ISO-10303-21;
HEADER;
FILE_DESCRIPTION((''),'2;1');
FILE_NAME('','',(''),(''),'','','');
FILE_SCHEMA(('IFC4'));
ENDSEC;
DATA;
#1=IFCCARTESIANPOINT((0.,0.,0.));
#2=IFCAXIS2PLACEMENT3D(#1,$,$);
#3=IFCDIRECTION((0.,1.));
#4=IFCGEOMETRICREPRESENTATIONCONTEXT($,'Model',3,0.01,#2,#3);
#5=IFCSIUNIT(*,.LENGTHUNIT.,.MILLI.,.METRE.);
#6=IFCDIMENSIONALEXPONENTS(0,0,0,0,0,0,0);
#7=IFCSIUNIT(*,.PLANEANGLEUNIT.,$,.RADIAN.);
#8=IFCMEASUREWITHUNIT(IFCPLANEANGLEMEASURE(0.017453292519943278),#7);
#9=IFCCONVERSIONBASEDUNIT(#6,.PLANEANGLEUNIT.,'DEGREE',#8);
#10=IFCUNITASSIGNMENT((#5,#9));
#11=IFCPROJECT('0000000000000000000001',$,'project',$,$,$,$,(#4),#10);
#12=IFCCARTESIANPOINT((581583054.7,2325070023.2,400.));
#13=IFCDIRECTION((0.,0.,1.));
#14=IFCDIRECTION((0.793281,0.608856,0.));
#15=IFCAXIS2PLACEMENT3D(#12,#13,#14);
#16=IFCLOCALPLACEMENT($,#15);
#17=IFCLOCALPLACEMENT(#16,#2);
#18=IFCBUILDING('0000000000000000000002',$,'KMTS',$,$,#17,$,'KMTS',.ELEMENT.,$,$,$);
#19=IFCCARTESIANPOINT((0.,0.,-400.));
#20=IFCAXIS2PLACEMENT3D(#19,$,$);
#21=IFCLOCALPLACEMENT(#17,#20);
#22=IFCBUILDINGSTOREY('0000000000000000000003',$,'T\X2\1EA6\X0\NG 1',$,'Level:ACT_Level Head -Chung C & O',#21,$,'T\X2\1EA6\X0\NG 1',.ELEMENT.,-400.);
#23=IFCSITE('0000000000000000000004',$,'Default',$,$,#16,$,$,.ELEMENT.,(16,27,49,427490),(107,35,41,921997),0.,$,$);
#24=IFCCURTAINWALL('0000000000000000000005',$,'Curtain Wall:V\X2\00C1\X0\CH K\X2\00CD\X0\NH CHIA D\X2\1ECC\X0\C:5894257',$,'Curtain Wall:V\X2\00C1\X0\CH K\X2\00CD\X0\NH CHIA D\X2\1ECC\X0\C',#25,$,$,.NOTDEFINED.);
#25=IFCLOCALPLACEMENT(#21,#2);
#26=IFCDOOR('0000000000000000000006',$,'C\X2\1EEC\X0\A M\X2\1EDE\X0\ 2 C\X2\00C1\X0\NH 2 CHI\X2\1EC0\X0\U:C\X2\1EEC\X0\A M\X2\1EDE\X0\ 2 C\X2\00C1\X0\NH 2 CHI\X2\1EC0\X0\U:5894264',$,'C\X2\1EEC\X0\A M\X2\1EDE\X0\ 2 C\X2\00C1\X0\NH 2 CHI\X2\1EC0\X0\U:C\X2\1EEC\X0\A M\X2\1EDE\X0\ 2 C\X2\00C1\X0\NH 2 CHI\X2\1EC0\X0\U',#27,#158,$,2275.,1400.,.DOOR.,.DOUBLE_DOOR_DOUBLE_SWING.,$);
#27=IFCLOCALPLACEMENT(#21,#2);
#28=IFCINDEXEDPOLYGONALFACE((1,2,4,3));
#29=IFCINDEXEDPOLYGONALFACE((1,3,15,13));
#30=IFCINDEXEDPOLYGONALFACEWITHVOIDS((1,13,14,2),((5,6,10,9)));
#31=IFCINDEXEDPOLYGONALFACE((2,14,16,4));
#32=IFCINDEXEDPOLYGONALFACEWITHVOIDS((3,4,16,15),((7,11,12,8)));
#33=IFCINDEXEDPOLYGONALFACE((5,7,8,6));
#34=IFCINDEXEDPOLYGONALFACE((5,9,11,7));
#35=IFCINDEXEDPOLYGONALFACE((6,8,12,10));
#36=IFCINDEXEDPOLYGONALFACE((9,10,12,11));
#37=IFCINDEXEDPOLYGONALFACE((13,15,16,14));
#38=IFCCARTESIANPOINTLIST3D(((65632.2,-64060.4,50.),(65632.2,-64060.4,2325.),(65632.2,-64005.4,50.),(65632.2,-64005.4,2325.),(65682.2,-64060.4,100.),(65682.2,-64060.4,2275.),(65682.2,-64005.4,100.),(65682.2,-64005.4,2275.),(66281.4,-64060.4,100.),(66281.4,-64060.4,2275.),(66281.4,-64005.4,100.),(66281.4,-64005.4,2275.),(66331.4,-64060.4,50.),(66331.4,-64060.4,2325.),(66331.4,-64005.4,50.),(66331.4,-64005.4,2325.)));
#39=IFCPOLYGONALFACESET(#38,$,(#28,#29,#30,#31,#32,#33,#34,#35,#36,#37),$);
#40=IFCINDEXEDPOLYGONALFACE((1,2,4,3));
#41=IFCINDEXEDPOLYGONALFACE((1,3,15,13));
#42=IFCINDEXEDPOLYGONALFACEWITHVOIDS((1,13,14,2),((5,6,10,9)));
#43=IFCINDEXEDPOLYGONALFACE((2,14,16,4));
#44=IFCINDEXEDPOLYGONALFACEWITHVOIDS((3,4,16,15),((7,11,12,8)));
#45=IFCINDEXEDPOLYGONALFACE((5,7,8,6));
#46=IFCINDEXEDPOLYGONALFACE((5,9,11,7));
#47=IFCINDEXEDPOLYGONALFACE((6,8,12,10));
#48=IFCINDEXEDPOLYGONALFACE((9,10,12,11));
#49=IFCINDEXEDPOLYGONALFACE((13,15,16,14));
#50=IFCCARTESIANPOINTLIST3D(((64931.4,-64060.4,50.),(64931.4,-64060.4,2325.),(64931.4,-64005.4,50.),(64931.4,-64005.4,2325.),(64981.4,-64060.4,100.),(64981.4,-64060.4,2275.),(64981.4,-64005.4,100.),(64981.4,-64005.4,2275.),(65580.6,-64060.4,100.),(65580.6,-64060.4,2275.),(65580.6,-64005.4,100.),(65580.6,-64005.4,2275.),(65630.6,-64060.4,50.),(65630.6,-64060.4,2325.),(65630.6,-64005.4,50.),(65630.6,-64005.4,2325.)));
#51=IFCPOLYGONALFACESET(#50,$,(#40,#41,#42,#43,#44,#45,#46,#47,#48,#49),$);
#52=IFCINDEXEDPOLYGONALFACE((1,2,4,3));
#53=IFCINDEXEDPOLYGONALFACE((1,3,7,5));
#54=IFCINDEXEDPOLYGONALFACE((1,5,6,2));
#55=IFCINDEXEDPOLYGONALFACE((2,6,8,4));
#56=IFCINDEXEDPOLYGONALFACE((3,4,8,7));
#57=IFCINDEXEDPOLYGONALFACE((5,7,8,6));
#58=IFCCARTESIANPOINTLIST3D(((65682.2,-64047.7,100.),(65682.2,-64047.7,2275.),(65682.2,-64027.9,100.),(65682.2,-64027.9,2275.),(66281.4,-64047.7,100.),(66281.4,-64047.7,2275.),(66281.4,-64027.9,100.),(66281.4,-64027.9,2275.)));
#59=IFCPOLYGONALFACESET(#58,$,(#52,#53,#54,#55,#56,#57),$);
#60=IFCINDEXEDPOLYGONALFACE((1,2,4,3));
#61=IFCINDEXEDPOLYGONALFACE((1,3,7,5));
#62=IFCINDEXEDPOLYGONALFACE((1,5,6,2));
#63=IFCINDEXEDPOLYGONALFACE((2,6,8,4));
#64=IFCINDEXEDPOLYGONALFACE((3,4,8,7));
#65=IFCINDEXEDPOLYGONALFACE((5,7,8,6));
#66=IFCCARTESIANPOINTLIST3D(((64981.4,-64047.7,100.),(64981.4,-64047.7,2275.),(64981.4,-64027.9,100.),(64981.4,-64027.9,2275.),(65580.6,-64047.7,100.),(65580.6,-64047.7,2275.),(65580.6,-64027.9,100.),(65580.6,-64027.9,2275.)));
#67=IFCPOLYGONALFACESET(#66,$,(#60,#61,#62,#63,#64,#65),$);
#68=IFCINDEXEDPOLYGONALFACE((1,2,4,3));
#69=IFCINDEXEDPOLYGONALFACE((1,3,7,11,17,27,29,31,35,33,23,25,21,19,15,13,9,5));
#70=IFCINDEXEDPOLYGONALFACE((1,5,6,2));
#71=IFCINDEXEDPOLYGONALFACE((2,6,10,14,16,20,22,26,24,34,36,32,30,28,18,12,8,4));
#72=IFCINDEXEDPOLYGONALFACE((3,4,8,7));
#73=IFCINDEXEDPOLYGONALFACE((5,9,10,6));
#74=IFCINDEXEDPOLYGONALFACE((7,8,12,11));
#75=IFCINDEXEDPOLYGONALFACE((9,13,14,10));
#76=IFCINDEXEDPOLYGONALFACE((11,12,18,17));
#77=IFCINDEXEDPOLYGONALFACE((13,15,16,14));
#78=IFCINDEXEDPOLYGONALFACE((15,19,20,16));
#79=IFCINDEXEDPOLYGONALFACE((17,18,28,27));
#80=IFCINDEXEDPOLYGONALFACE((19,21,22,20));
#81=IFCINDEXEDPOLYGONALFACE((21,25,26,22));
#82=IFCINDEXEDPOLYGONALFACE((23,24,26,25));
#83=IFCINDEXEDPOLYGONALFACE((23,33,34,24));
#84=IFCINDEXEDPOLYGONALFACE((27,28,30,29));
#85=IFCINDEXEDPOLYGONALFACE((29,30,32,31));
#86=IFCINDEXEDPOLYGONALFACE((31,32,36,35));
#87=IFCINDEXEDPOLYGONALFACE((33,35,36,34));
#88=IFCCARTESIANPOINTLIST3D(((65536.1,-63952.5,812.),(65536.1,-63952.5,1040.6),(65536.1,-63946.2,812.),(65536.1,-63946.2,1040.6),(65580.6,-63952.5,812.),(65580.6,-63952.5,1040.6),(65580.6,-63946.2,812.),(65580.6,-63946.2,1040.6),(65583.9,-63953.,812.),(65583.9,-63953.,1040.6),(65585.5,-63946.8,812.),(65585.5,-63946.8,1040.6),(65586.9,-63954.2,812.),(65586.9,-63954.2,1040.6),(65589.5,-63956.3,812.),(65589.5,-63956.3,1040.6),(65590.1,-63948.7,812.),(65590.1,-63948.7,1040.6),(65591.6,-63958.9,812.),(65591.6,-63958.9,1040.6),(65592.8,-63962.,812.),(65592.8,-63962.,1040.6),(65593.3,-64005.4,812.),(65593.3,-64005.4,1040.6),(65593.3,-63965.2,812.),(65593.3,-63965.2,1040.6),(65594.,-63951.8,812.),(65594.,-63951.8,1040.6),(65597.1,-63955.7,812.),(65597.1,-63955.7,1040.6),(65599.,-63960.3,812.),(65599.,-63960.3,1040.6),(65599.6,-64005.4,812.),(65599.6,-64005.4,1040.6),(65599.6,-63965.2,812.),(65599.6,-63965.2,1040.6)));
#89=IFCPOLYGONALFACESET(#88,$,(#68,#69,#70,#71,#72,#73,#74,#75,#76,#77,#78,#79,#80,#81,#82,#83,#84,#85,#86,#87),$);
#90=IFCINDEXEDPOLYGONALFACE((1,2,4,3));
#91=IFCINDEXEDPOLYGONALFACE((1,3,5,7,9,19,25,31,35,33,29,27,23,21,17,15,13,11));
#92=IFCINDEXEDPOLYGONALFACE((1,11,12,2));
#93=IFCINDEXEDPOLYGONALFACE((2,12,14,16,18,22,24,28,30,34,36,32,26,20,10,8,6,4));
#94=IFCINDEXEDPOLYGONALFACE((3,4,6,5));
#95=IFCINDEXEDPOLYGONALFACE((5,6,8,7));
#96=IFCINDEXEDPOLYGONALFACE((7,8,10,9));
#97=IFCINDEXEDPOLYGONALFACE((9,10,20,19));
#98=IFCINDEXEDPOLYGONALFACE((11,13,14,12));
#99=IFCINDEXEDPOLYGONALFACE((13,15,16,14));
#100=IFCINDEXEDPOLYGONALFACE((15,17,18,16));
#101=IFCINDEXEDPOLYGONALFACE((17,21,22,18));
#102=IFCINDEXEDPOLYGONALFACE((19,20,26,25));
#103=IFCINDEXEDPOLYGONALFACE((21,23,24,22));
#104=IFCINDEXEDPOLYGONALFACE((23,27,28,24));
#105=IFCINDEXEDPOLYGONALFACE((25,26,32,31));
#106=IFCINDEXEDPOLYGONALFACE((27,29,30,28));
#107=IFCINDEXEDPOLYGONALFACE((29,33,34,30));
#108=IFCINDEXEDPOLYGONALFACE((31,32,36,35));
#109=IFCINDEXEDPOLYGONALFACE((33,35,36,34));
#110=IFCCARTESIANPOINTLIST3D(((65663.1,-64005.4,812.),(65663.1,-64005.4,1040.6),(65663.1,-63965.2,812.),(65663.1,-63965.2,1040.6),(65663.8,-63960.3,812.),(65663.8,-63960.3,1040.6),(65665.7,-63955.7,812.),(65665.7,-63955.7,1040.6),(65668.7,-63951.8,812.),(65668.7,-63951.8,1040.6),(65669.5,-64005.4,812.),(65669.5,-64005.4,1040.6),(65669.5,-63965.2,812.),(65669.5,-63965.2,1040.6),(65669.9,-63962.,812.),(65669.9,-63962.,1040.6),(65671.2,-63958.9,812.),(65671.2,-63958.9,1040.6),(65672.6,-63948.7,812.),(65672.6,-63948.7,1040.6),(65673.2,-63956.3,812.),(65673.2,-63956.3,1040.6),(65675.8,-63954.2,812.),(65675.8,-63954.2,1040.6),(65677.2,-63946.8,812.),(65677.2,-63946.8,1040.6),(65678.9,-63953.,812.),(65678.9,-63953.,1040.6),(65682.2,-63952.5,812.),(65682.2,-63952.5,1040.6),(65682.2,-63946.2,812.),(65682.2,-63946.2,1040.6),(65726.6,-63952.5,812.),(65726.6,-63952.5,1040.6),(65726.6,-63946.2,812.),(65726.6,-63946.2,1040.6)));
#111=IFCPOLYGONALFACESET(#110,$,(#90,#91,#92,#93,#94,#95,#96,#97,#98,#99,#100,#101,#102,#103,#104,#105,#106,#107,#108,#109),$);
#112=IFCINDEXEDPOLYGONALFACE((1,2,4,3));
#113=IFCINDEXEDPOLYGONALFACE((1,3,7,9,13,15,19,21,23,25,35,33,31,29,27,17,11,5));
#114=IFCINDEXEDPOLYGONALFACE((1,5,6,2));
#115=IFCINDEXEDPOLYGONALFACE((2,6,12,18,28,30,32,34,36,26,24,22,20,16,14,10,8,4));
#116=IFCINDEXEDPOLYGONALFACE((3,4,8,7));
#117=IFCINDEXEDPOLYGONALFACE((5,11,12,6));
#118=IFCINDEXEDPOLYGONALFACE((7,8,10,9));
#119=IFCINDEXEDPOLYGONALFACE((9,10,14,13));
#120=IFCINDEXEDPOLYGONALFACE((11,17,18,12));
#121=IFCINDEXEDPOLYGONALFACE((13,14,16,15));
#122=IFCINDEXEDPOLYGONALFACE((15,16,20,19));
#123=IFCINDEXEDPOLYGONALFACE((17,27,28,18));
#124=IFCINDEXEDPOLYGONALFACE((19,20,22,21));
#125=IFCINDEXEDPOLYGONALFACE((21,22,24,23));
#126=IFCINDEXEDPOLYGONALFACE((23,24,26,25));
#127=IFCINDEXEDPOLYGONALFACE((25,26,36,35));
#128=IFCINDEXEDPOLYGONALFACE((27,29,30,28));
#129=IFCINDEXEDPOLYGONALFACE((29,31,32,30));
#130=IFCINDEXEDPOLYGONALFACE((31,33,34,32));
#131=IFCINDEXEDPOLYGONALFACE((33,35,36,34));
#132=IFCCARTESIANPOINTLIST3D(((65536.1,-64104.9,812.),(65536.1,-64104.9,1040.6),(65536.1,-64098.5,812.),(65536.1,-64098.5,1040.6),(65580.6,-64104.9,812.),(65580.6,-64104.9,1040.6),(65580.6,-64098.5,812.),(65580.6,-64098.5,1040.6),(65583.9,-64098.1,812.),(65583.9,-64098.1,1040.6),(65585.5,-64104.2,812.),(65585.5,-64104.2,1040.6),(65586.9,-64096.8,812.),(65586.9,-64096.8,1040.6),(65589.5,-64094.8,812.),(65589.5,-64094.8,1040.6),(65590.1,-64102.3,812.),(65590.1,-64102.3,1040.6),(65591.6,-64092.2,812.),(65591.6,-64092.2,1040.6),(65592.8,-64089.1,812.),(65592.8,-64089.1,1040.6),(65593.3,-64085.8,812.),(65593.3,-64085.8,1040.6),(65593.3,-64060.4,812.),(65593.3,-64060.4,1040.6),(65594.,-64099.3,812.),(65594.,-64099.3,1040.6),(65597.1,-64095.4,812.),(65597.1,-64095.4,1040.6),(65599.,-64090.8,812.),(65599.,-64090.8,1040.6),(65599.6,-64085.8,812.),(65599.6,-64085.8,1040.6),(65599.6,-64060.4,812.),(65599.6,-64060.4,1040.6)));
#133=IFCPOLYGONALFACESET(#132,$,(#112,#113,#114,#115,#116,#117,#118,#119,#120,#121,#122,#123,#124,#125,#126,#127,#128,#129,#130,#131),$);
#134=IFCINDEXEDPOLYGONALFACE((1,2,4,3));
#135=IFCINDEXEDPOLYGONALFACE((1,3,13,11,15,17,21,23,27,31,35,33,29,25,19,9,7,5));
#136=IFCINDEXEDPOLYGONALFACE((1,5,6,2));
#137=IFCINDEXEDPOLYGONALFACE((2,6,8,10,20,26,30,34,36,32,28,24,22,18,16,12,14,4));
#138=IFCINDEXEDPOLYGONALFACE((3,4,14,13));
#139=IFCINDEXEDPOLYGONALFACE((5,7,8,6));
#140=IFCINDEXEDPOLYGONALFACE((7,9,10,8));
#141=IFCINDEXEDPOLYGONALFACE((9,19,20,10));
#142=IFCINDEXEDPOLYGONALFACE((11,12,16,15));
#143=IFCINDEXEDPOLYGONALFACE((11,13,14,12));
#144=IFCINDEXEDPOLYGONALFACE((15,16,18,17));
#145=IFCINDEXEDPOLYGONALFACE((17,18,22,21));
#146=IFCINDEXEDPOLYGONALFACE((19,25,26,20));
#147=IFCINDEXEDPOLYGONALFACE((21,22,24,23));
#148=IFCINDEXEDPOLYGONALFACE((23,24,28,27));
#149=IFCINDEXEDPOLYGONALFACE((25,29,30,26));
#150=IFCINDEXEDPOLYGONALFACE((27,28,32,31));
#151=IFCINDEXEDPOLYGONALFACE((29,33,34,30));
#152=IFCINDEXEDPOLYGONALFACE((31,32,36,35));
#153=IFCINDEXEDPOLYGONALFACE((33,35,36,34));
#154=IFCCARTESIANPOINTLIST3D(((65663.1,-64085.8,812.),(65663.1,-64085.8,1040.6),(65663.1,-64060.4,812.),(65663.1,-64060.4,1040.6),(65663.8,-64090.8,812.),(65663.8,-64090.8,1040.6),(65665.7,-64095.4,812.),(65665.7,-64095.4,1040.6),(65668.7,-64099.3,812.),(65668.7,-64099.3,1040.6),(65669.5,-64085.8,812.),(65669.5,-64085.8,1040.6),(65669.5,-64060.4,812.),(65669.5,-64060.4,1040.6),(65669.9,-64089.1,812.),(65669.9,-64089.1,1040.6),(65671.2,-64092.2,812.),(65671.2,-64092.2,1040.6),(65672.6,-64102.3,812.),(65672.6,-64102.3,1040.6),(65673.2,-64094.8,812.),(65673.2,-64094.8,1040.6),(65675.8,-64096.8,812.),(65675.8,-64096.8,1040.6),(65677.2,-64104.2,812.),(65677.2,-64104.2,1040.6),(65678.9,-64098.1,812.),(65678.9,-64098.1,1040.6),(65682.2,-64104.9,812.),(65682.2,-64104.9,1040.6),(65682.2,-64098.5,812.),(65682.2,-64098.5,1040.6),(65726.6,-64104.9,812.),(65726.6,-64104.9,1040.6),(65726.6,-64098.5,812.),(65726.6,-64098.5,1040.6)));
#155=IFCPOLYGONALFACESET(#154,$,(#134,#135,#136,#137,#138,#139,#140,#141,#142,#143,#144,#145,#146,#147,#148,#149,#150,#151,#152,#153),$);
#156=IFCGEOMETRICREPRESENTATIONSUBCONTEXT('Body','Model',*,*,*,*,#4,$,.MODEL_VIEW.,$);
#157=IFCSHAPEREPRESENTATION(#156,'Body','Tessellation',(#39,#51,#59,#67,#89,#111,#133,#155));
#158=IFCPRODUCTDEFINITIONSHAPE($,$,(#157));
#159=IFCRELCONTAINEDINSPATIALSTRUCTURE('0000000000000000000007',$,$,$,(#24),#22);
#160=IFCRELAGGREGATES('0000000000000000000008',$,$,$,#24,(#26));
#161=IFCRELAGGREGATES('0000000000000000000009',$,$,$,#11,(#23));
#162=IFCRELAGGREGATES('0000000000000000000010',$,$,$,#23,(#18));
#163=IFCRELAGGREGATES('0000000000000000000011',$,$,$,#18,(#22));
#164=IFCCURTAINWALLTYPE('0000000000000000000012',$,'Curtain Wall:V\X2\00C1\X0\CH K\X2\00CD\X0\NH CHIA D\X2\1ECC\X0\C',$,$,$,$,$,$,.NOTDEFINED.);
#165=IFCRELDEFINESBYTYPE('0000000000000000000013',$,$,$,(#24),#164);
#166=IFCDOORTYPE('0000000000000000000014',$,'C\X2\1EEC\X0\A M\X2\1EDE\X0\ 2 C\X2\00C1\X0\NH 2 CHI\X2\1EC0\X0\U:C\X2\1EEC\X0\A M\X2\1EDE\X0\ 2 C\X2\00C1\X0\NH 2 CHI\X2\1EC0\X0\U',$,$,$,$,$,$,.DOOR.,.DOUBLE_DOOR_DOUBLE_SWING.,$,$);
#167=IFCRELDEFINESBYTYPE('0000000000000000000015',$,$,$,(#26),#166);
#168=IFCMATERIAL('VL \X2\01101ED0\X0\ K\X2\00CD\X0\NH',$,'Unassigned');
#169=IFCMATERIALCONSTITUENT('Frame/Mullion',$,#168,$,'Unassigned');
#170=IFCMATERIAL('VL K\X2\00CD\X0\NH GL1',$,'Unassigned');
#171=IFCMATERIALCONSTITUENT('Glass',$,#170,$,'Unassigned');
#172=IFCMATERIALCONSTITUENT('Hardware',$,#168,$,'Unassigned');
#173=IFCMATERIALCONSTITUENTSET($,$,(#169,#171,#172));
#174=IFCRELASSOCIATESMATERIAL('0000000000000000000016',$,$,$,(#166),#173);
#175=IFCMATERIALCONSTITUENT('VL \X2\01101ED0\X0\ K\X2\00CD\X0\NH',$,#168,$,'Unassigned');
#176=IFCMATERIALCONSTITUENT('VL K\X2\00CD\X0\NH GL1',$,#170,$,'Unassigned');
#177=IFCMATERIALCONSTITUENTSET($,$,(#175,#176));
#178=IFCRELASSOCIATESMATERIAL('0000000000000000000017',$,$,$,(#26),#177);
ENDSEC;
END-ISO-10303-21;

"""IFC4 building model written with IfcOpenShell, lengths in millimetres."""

from ifc_helpers import new_model, entity, si_unit, converted_unit, direction, frame, origin, place, context, subcontext, project, spatial, line, arc, indexed_curve, outline, extrude, source, transform, mapped, material, constituent, constituent_set, type_object, type_shapes, element, aggregate, save


model = new_model("IFC4")

# Units and contexts
model_context = context("Model", 3, precision=0.01, world=origin(), true_north=direction((0.0, 1.0)))
body_context = subcontext(model_context, "Body", "Model", "MODEL_VIEW")
ifc_project = project(units=[si_unit("LENGTHUNIT", "METRE", prefix="MILLI"), converted_unit("PLANEANGLEUNIT", "DEGREE", entity("IfcPlaneAngleMeasure", 0.017453292519943278), si_unit("PLANEANGLEUNIT", "RADIAN"), dimensions=[0, 0, 0, 0, 0, 0, 0])], contexts=[model_context])

# Site, building, storey
site_placement = place(None, frame((581583054.7, 2325070023.2, 400.0), z_axis=(0.0, 0.0, 1.0), x_axis=(0.793281, 0.608856, 0.0)))
site = spatial("IfcSite", under=ifc_project, at=site_placement, Name="Default", CompositionType="ELEMENT", RefLatitude=(16, 27, 49, 427490), RefLongitude=(107, 35, 41, 921997), RefElevation=0.0)
building_placement = place(site_placement, origin())
building = spatial("IfcBuilding", under=site, at=building_placement, Name="KMTS", LongName="KMTS", CompositionType="ELEMENT")
storey_placement = place(building_placement, frame((0.0, 0.0, -400.0)))
storey = spatial("IfcBuildingStorey", under=building, at=storey_placement, Name="TẦNG 1", ObjectType="Level:ACT_Level Head -Chung C & O", LongName="TẦNG 1", CompositionType="ELEMENT", Elevation=-400.0)

# Shared definitions
curtain_wall_type = type_object("IfcCurtainWallType", Name="Curtain Wall:VÁCH KÍNH CHIA DỌC", PredefinedType="NOTDEFINED")
ifc_material_1 = material(Name="VL ĐỐ KÍNH", Category="Unassigned")

# Curtain wall
curtain_wall_1_placement = place(storey_placement, frame((0.0, 0.0, 400.0)))
curtain_wall_1 = element("IfcCurtainWall", 1, at=curtain_wall_1_placement, inside=storey, type_object=curtain_wall_type, Name="Curtain Wall:VÁCH KÍNH CHIA DỌC:5894257", ObjectType="Curtain Wall:VÁCH KÍNH CHIA DỌC", PredefinedType="NOTDEFINED")

# Door
ifc_material_2 = material(Name="VL KÍNH GL1", Category="Unassigned")
ifc_constituent_1 = constituent(ifc_material_1, Name="VL ĐỐ KÍNH", Category="Unassigned")
ifc_constituent_2 = constituent(ifc_material_2, Name="VL KÍNH GL1", Category="Unassigned")
ifc_constituent_set_1 = constituent_set(constituents=[ifc_constituent_1, ifc_constituent_2])
ifc_constituent_3 = constituent(ifc_material_1, Name="Frame/Mullion", Category="Unassigned")
ifc_constituent_4 = constituent(ifc_material_2, Name="Glass", Category="Unassigned")
ifc_constituent_5 = constituent(ifc_material_1, Name="Hardware", Category="Unassigned")
ifc_constituent_set_2 = constituent_set(constituents=[ifc_constituent_3, ifc_constituent_4, ifc_constituent_5])
door_type_1 = type_object("IfcDoorType", Name="CỬA MỞ 2 CÁNH 2 CHIỀU:CỬA MỞ 2 CÁNH 2 CHIỀU", OperationType="DOUBLE_DOOR_DOUBLE_SWING", PredefinedType="DOOR", material=ifc_constituent_set_2)
shared_shape_1 = source(origin(), body_context, "Body", "SweptSolid", [
    extrude(outline(indexed_curve([(-1137.5, -349.6), (1137.5, -349.6), (1137.5, 349.6), (-1137.5, 349.6), (-1137.5, -349.6)], self_intersect=False), holes=[indexed_curve([(-1087.5, 299.6), (1087.5, 299.6), (1087.5, -299.6), (-1087.5, -299.6), (-1087.5, 299.6)], self_intersect=False)]), frame((-350.4, -27.5, 1137.5), z_axis=(0.0, 1.0, 0.0), x_axis=(0.0, 0.0, -1.0)), (0.0, 0.0, 1.0), 55.0),
    extrude(outline(indexed_curve([(-349.6, -1137.5), (349.6, -1137.5), (349.6, 1137.5), (-349.6, 1137.5), (-349.6, -1137.5)], self_intersect=False), holes=[indexed_curve([(-299.6, -1087.5), (-299.6, 1087.5), (299.6, 1087.5), (299.6, -1087.5), (-299.6, -1087.5)], self_intersect=False)]), frame((350.4, -27.5, 1137.5), z_axis=(0.0, 1.0, 0.0), x_axis=(1.0, 0.0, 0.0)), (0.0, 0.0, 1.0), 55.0),
    extrude(outline(indexed_curve([(-9.9, -299.6), (9.9, -299.6), (9.9, 299.6), (-9.9, 299.6), (-9.9, -299.6)], self_intersect=False)), frame((-350.4, 4.9, 50.0), z_axis=(0.0, 0.0, 1.0), x_axis=(0.0, 1.0, 0.0)), (0.0, 0.0, 1.0), 2175.0),
    extrude(outline(indexed_curve([(-9.9, -299.6), (9.9, -299.6), (9.9, 299.6), (-9.9, 299.6), (-9.9, -299.6)], self_intersect=False)), frame((350.4, 4.9, 50.0), z_axis=(0.0, 0.0, 1.0), x_axis=(0.0, 1.0, 0.0)), (0.0, 0.0, 1.0), 2175.0),
    extrude(outline(indexed_curve([(-22.2, -2.1), (-16.6, -15.6), (-3.2, -21.2), (41.3, -21.2), (41.3, -14.8), (-3.2, -14.8), (-12.2, -11.1), (-15.9, -2.1), (-15.9, 38.1), (-22.2, 38.1)], segments=[arc(1, 2, 3), line(3, 4, 5, 6), arc(6, 7, 8), line(8, 9, 10, 1)], self_intersect=False)), frame((54.0, -65.6, 762.0)), (0.0, 0.0, 1.0), 228.6),
    extrude(outline(indexed_curve([(-2.1, -22.2), (38.1, -22.2), (38.1, -15.9), (-2.1, -15.9), (-11.1, -12.2), (-14.8, -3.2), (-14.8, 41.3), (-21.2, 41.3), (-21.2, -3.2), (-15.6, -16.6)], segments=[line(1, 2, 3, 4), arc(4, 5, 6), line(6, 7, 8, 9), arc(9, 10, 1)], self_intersect=False)), frame((-54.0, -65.6, 762.0), z_axis=(0.0, 0.0, 1.0), x_axis=(0.0, 1.0, 0.0)), (0.0, 0.0, 1.0), 228.6),
    extrude(outline(indexed_curve([(1.6, -22.2), (27.0, -22.2), (27.0, -15.9), (1.6, -15.9), (-7.4, -12.2), (-11.1, -3.2), (-11.1, 41.3), (-17.5, 41.3), (-17.5, -3.2), (-11.9, -16.6)], segments=[line(1, 2, 3, 4), arc(4, 5, 6), line(6, 7, 8, 9), arc(9, 10, 1)], self_intersect=False)), frame((54.0, 54.5, 762.0), z_axis=(0.0, 0.0, 1.0), x_axis=(0.0, -1.0, 0.0)), (0.0, 0.0, 1.0), 228.6),
    extrude(outline(indexed_curve([(22.2, -1.6), (16.6, 11.9), (3.2, 17.5), (-41.3, 17.5), (-41.3, 11.1), (3.2, 11.1), (12.2, 7.4), (15.9, -1.6), (15.9, -27.0), (22.2, -27.0)], segments=[arc(1, 2, 3), line(3, 4, 5, 6), arc(6, 7, 8), line(8, 9, 10, 1)], self_intersect=False)), frame((-54.0, 54.5, 762.0)), (0.0, 0.0, 1.0), 228.6),
])
type_shapes(door_type_1, [shared_shape_1])
door_1_placement = place(curtain_wall_1_placement, frame((65631.4, -64032.9, -350.0), z_axis=(0.0, 0.0, 1.0), x_axis=(-1.0, 0.0, 0.0)))
door_1 = element("IfcDoor", 2, at=door_1_placement, type_object=door_type_1, material=ifc_constituent_set_1, Name="CỬA MỞ 2 CÁNH 2 CHIỀU:CỬA MỞ 2 CÁNH 2 CHIỀU:5894264", ObjectType="CỬA MỞ 2 CÁNH 2 CHIỀU:CỬA MỞ 2 CÁNH 2 CHIỀU", OperationType="DOUBLE_DOOR_DOUBLE_SWING", OverallHeight=2275.0, OverallWidth=1400.0, PredefinedType="DOOR", context=body_context, shape_type="MappedRepresentation", body=[
    mapped(shared_shape_1, transform((0.0, 0.0, 0.0), scale=1.0)),
])
aggregate(curtain_wall_1, [door_1])

save(model, "model.ifc")
